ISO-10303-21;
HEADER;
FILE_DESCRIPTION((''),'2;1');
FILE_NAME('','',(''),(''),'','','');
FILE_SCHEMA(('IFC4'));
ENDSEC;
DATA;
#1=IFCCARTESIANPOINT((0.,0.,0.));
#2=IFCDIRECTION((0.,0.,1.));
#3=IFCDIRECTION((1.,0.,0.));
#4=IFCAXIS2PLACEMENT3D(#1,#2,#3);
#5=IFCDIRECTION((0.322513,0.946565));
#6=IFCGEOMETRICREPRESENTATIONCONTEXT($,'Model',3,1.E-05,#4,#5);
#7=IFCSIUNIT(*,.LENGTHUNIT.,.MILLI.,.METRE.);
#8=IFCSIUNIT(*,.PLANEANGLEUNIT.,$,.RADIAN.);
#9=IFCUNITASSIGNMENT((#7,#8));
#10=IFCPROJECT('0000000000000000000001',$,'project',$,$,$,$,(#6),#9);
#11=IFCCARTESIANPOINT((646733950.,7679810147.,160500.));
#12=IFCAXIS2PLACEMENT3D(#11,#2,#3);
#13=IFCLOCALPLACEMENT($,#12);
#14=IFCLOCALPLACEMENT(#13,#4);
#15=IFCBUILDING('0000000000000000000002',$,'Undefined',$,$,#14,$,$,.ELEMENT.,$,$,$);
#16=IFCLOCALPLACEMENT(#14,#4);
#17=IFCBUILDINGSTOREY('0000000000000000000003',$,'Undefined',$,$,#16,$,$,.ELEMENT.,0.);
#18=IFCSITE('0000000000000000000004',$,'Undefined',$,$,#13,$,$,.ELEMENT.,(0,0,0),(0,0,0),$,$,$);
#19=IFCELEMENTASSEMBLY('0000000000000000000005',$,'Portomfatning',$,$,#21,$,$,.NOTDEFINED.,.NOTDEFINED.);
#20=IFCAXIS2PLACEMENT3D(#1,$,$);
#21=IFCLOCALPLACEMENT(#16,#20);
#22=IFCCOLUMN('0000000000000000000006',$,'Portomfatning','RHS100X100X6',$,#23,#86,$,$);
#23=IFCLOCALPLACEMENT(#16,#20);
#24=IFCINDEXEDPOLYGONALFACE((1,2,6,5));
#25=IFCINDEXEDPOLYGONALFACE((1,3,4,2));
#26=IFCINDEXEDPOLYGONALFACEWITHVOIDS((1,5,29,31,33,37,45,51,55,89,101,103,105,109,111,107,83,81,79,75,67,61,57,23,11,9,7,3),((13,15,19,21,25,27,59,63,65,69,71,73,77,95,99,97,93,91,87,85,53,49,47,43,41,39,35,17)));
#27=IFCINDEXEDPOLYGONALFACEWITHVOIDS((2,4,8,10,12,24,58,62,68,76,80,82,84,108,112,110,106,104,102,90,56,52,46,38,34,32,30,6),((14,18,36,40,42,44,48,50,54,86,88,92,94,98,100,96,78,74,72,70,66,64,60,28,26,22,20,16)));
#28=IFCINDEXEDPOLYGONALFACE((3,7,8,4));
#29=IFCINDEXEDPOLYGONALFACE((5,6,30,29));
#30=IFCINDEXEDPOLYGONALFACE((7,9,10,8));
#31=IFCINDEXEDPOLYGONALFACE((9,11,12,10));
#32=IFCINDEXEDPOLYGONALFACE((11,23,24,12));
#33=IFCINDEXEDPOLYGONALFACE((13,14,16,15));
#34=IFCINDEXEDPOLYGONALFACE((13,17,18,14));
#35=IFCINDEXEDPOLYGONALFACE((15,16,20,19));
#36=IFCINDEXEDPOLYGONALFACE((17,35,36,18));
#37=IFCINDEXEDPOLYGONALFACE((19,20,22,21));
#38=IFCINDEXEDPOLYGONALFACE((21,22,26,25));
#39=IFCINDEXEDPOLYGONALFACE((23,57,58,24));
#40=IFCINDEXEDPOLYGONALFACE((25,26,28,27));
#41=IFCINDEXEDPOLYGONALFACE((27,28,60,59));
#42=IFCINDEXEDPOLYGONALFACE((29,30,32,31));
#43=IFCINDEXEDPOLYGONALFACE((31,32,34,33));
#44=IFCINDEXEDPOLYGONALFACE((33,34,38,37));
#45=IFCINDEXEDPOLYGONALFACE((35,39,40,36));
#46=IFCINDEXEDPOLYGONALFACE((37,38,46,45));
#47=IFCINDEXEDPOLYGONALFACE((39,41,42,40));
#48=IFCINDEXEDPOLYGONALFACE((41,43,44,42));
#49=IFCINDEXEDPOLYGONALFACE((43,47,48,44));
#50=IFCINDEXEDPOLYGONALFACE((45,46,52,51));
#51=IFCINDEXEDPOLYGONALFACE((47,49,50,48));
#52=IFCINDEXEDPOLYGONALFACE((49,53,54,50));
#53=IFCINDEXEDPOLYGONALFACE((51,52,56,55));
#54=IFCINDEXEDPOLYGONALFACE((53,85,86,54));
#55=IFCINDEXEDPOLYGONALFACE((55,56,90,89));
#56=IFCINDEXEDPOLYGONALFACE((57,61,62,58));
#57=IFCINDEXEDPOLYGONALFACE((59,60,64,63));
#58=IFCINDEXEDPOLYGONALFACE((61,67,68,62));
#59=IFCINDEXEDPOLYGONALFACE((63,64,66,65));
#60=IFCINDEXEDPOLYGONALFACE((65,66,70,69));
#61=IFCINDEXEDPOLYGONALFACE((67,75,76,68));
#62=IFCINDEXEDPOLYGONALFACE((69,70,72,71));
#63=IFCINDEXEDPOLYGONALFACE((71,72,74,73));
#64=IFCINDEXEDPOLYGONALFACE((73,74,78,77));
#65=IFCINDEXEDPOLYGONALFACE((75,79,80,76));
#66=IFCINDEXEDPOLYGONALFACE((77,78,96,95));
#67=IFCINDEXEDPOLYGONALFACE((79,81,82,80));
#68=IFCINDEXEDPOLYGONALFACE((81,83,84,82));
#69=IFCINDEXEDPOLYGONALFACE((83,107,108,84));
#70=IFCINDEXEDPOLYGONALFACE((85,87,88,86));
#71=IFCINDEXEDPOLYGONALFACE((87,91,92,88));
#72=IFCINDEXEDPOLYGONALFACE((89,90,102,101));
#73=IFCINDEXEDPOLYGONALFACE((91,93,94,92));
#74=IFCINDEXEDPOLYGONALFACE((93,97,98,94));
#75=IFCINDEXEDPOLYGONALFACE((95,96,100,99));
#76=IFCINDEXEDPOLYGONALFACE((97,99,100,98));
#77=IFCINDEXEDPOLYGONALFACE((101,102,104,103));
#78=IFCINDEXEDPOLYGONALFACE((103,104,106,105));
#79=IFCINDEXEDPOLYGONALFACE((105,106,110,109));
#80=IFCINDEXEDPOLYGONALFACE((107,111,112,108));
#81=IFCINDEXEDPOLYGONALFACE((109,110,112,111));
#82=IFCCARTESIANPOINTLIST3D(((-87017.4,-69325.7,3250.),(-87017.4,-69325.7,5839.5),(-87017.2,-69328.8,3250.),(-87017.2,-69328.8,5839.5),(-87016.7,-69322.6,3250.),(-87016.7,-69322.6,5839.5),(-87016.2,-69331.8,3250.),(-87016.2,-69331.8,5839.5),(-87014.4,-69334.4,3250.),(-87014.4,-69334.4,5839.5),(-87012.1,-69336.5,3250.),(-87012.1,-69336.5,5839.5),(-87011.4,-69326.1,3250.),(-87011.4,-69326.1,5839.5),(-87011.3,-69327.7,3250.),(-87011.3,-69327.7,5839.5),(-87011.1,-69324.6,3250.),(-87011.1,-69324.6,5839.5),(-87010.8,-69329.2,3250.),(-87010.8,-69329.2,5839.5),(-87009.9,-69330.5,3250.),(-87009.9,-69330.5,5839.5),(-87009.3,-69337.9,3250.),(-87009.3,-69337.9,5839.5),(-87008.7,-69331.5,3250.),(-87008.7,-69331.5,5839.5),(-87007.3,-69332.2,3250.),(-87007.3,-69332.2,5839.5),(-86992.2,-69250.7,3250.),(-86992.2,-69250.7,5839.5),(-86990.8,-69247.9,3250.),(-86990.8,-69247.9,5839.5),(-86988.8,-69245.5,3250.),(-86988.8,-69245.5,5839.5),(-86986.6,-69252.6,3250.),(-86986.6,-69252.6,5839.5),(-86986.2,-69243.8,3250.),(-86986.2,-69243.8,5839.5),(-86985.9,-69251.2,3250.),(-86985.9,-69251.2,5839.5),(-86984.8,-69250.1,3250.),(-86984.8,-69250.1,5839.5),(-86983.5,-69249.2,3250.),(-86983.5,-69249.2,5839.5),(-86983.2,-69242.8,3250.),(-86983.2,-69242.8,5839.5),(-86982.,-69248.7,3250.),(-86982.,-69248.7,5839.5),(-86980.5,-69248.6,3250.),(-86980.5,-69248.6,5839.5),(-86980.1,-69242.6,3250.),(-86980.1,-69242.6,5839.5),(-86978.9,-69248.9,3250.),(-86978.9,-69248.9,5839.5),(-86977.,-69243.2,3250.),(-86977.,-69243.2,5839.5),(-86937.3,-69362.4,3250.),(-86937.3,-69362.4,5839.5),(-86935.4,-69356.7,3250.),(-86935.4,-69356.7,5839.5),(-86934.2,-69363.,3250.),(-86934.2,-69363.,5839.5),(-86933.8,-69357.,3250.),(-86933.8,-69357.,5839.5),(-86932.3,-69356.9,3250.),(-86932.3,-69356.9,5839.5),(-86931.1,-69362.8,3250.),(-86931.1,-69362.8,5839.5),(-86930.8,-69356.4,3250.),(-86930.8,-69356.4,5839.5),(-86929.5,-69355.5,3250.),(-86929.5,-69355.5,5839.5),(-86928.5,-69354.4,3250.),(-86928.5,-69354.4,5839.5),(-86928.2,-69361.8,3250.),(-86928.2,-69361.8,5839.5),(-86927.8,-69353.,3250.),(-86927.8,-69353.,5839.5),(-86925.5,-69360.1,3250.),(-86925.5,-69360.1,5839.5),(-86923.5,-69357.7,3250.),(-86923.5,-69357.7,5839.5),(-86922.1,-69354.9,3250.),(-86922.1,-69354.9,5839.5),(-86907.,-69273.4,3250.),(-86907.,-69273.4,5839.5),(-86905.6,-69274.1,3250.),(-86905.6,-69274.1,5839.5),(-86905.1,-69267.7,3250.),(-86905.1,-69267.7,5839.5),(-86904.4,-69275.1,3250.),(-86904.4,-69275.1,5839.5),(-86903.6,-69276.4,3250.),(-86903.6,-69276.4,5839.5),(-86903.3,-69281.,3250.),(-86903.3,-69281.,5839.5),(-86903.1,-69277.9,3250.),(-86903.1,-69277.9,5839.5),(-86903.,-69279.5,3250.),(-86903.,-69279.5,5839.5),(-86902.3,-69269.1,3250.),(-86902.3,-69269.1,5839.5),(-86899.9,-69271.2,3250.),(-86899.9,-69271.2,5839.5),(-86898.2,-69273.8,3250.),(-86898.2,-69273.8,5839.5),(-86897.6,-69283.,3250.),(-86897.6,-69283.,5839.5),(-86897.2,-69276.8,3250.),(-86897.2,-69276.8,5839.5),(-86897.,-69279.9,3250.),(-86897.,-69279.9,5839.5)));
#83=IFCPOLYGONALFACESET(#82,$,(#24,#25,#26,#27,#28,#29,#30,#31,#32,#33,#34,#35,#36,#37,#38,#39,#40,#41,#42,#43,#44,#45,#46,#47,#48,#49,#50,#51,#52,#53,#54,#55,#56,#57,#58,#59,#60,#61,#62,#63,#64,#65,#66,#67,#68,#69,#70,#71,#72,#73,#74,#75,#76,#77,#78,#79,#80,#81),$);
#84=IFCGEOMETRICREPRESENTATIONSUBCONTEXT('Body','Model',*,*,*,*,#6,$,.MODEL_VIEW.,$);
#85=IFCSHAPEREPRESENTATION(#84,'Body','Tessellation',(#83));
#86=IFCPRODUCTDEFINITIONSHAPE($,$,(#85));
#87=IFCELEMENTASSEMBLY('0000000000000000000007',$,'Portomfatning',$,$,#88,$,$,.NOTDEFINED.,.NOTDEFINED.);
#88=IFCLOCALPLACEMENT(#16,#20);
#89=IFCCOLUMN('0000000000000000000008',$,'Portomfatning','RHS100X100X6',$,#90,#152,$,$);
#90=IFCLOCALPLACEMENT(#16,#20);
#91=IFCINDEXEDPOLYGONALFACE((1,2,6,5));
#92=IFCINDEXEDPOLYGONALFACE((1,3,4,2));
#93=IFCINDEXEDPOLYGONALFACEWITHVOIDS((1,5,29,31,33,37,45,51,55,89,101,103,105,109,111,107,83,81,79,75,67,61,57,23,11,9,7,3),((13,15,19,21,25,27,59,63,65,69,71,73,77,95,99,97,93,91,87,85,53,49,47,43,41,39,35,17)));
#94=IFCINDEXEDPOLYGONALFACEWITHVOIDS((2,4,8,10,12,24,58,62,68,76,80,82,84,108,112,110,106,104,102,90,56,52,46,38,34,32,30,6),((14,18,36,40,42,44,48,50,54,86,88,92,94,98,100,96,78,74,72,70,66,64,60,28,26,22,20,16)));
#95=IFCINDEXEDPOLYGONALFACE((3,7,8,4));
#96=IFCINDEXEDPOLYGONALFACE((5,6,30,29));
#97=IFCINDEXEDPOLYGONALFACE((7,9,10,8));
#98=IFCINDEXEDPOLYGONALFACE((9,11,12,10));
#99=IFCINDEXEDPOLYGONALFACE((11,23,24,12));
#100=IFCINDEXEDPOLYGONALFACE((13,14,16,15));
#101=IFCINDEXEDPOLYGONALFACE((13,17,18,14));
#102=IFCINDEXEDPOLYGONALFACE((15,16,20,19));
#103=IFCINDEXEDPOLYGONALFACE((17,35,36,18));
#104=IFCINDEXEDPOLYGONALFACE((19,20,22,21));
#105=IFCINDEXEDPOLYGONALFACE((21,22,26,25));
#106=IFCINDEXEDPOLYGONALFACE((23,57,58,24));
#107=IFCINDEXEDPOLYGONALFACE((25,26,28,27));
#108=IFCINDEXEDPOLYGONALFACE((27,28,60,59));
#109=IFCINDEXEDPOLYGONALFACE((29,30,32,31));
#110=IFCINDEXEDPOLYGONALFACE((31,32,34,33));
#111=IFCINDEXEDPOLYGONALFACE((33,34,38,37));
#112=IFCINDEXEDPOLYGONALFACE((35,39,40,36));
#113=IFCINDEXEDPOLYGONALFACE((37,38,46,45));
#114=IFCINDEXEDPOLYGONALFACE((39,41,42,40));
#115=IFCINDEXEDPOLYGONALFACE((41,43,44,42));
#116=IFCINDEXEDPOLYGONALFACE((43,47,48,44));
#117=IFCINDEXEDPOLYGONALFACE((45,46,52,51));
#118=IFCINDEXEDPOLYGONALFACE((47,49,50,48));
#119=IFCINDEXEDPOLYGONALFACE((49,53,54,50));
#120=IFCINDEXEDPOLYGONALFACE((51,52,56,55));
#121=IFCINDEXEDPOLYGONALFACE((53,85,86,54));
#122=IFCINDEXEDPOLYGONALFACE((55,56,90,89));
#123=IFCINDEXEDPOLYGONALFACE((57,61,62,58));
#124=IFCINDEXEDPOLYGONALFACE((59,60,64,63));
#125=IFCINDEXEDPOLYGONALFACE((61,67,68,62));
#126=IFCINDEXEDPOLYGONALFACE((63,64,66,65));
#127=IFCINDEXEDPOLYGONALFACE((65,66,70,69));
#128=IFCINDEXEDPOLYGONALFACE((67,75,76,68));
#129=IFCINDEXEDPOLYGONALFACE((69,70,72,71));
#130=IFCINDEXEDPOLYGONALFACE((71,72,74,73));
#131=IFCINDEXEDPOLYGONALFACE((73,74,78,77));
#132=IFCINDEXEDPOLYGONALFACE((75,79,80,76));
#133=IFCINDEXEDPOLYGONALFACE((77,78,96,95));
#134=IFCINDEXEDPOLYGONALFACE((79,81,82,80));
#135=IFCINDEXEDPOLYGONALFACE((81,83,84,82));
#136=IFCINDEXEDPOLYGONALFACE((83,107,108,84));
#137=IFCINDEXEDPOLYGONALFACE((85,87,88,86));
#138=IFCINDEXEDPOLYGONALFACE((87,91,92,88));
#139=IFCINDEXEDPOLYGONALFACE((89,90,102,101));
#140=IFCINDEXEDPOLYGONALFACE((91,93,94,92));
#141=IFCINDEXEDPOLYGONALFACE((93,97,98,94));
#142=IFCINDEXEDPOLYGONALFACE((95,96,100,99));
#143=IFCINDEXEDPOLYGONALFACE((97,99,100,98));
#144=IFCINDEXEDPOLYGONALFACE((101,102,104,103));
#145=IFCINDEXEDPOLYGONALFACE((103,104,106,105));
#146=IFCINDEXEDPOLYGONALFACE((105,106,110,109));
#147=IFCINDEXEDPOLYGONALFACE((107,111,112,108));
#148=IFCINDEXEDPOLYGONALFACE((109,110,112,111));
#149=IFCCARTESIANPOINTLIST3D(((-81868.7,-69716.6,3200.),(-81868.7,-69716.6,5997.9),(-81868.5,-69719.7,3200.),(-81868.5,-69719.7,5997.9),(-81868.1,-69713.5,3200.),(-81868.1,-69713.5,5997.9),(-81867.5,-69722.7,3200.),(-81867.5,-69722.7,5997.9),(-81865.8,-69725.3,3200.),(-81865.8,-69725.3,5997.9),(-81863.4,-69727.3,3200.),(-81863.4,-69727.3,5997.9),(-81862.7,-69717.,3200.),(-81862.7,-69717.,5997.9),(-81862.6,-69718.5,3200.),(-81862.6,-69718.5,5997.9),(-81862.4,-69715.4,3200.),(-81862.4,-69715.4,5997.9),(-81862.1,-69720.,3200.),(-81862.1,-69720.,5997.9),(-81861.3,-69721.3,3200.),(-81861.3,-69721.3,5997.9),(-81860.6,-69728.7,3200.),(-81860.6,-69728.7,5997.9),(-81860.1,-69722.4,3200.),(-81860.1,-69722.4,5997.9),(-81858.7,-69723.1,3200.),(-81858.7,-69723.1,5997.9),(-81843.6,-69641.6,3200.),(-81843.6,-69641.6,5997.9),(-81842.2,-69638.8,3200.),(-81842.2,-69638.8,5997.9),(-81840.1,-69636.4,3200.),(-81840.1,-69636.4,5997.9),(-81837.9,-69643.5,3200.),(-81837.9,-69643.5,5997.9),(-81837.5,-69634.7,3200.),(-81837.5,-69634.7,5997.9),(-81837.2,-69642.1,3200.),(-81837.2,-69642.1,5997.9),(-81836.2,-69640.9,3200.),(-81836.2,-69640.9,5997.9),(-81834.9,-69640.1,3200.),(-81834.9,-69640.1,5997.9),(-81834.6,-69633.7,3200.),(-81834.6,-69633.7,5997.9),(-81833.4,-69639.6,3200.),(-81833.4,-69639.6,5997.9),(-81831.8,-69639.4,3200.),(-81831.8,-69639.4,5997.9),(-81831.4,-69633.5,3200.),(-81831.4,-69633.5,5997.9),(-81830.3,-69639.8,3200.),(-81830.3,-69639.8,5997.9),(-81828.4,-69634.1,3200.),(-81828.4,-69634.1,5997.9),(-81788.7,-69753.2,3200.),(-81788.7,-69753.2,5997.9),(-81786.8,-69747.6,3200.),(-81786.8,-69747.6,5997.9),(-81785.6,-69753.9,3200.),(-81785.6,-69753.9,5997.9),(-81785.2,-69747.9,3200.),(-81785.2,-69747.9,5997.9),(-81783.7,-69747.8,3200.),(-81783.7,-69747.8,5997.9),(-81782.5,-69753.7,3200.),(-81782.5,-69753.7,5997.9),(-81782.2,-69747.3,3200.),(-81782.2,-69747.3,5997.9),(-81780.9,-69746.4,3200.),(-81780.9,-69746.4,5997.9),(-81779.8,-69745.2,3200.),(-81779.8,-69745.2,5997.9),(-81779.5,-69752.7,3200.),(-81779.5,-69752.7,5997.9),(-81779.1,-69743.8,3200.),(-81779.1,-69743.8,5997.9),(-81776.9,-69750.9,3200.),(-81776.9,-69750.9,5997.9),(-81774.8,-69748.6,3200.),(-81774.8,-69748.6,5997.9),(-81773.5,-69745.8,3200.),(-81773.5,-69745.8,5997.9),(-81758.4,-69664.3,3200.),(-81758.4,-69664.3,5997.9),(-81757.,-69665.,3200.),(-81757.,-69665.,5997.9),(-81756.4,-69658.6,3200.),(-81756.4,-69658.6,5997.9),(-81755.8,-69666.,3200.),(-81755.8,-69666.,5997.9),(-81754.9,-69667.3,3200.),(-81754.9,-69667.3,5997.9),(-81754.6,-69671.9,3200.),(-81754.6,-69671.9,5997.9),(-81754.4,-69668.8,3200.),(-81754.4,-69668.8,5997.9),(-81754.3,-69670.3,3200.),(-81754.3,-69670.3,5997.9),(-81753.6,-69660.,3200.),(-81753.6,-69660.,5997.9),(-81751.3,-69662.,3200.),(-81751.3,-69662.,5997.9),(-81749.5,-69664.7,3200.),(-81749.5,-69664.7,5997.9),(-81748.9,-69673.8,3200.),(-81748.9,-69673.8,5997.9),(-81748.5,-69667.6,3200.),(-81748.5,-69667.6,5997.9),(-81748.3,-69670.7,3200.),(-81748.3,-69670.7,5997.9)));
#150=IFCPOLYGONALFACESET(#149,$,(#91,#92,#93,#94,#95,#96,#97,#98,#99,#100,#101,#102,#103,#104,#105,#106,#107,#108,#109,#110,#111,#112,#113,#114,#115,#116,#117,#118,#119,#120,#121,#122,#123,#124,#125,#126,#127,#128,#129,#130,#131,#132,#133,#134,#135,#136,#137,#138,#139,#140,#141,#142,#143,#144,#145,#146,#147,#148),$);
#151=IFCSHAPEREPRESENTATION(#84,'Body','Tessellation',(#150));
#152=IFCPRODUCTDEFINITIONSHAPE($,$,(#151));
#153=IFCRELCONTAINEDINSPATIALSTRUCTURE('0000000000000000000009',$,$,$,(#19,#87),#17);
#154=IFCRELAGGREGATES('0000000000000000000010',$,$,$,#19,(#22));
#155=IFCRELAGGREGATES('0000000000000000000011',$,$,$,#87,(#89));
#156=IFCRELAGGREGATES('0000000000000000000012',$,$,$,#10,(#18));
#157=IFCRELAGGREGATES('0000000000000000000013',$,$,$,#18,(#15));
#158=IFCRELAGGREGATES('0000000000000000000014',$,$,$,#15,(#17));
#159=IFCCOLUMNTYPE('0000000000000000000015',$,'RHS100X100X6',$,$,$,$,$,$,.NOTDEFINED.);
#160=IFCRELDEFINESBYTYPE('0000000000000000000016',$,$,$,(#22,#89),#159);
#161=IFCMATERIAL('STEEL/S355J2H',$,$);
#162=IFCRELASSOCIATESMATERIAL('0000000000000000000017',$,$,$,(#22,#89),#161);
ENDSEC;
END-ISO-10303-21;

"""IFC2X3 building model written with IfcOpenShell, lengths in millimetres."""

from ifc_helpers import new_model, si_unit, direction, frame, origin_with_axes, origin_2d_with_axis, place, context, subcontext, project, spatial, hollow_rectangle, extrude, material, type_object, element, aggregate, save


model = new_model("IFC2X3")

# Units and contexts
model_context = context("Model", 3, precision=1e-05, world=origin_with_axes(), true_north=direction((0.322513, 0.946565)))
body_context = subcontext(model_context, "Body", "Model", "MODEL_VIEW")
ifc_project = project(units=[si_unit("LENGTHUNIT", "METRE", prefix="MILLI"), si_unit("PLANEANGLEUNIT", "RADIAN")], contexts=[model_context])

# Site, building, storey
site_placement = place(None, frame((646733950.0, 7679810147.0, 160500.0), z_axis=(0.0, 0.0, 1.0), x_axis=(1.0, 0.0, 0.0)))
site = spatial("IfcSite", under=ifc_project, at=site_placement, Name="Undefined", CompositionType="ELEMENT", RefLatitude=(0, 0, 0), RefLongitude=(0, 0, 0))
building_placement = place(site_placement, origin_with_axes())
building = spatial("IfcBuilding", under=site, at=building_placement, Name="Undefined", CompositionType="ELEMENT")
storey_placement = place(building_placement, origin_with_axes())
storey = spatial("IfcBuildingStorey", under=building, at=storey_placement, Name="Undefined", CompositionType="ELEMENT", Elevation=0.0)

# Element assemblies, columns
assembly_1_placement = place(storey_placement, origin_with_axes())
assembly_1 = element("IfcElementAssembly", 1, at=assembly_1_placement, inside=storey, Name="Portomfatning", AssemblyPlace="NOTDEFINED", PredefinedType="NOTDEFINED")
ifc_material_1 = material(Name="STEEL/S355J2H")
column_type_1 = type_object("IfcColumnType", Name="RHS100X100X6", PredefinedType="NOTDEFINED")
column_1_placement = place(assembly_1_placement, frame((-86957.2, -69302.8, 3250.0), z_axis=(0.0, 0.0, 1.0), x_axis=(-0.322513, -0.946565, 0.0)))
column_1 = element("IfcColumn", 2, at=column_1_placement, type_object=column_type_1, material=ifc_material_1, Name="Portomfatning", Description="RHS100X100X6", context=body_context, shape_type="SweptSolid", body=[
    extrude(hollow_rectangle(XDim=100.0, YDim=100.0, WallThickness=6.0, InnerFilletRadius=6.0, OuterFilletRadius=12.0, at=origin_2d_with_axis()), frame((0.0, 0.0, 2589.5), z_axis=(0.0, 0.0, -1.0), x_axis=(0.0, 1.0, 0.0)), (0.0, 0.0, 1.0), 2589.5),
])
aggregate(assembly_1, [column_1])
assembly_2_placement = place(storey_placement, origin_with_axes())
assembly_2 = element("IfcElementAssembly", 3, at=assembly_2_placement, inside=storey, Name="Portomfatning", AssemblyPlace="NOTDEFINED", PredefinedType="NOTDEFINED")
column_2_placement = place(assembly_2_placement, frame((-81808.5, -69693.7, 3200.0), z_axis=(0.0, 0.0, 1.0), x_axis=(-0.322513, -0.946565, 0.0)))
column_2 = element("IfcColumn", 4, at=column_2_placement, type_object=column_type_1, material=ifc_material_1, Name="Portomfatning", Description="RHS100X100X6", context=body_context, shape_type="SweptSolid", body=[
    extrude(hollow_rectangle(XDim=100.0, YDim=100.0, WallThickness=6.0, InnerFilletRadius=6.0, OuterFilletRadius=12.0, at=origin_2d_with_axis()), frame((0.0, 0.0, 2797.9), z_axis=(0.0, 0.0, -1.0), x_axis=(0.0, 1.0, 0.0)), (0.0, 0.0, 1.0), 2797.9),
])
aggregate(assembly_2, [column_2])

save(model, "model.ifc")
